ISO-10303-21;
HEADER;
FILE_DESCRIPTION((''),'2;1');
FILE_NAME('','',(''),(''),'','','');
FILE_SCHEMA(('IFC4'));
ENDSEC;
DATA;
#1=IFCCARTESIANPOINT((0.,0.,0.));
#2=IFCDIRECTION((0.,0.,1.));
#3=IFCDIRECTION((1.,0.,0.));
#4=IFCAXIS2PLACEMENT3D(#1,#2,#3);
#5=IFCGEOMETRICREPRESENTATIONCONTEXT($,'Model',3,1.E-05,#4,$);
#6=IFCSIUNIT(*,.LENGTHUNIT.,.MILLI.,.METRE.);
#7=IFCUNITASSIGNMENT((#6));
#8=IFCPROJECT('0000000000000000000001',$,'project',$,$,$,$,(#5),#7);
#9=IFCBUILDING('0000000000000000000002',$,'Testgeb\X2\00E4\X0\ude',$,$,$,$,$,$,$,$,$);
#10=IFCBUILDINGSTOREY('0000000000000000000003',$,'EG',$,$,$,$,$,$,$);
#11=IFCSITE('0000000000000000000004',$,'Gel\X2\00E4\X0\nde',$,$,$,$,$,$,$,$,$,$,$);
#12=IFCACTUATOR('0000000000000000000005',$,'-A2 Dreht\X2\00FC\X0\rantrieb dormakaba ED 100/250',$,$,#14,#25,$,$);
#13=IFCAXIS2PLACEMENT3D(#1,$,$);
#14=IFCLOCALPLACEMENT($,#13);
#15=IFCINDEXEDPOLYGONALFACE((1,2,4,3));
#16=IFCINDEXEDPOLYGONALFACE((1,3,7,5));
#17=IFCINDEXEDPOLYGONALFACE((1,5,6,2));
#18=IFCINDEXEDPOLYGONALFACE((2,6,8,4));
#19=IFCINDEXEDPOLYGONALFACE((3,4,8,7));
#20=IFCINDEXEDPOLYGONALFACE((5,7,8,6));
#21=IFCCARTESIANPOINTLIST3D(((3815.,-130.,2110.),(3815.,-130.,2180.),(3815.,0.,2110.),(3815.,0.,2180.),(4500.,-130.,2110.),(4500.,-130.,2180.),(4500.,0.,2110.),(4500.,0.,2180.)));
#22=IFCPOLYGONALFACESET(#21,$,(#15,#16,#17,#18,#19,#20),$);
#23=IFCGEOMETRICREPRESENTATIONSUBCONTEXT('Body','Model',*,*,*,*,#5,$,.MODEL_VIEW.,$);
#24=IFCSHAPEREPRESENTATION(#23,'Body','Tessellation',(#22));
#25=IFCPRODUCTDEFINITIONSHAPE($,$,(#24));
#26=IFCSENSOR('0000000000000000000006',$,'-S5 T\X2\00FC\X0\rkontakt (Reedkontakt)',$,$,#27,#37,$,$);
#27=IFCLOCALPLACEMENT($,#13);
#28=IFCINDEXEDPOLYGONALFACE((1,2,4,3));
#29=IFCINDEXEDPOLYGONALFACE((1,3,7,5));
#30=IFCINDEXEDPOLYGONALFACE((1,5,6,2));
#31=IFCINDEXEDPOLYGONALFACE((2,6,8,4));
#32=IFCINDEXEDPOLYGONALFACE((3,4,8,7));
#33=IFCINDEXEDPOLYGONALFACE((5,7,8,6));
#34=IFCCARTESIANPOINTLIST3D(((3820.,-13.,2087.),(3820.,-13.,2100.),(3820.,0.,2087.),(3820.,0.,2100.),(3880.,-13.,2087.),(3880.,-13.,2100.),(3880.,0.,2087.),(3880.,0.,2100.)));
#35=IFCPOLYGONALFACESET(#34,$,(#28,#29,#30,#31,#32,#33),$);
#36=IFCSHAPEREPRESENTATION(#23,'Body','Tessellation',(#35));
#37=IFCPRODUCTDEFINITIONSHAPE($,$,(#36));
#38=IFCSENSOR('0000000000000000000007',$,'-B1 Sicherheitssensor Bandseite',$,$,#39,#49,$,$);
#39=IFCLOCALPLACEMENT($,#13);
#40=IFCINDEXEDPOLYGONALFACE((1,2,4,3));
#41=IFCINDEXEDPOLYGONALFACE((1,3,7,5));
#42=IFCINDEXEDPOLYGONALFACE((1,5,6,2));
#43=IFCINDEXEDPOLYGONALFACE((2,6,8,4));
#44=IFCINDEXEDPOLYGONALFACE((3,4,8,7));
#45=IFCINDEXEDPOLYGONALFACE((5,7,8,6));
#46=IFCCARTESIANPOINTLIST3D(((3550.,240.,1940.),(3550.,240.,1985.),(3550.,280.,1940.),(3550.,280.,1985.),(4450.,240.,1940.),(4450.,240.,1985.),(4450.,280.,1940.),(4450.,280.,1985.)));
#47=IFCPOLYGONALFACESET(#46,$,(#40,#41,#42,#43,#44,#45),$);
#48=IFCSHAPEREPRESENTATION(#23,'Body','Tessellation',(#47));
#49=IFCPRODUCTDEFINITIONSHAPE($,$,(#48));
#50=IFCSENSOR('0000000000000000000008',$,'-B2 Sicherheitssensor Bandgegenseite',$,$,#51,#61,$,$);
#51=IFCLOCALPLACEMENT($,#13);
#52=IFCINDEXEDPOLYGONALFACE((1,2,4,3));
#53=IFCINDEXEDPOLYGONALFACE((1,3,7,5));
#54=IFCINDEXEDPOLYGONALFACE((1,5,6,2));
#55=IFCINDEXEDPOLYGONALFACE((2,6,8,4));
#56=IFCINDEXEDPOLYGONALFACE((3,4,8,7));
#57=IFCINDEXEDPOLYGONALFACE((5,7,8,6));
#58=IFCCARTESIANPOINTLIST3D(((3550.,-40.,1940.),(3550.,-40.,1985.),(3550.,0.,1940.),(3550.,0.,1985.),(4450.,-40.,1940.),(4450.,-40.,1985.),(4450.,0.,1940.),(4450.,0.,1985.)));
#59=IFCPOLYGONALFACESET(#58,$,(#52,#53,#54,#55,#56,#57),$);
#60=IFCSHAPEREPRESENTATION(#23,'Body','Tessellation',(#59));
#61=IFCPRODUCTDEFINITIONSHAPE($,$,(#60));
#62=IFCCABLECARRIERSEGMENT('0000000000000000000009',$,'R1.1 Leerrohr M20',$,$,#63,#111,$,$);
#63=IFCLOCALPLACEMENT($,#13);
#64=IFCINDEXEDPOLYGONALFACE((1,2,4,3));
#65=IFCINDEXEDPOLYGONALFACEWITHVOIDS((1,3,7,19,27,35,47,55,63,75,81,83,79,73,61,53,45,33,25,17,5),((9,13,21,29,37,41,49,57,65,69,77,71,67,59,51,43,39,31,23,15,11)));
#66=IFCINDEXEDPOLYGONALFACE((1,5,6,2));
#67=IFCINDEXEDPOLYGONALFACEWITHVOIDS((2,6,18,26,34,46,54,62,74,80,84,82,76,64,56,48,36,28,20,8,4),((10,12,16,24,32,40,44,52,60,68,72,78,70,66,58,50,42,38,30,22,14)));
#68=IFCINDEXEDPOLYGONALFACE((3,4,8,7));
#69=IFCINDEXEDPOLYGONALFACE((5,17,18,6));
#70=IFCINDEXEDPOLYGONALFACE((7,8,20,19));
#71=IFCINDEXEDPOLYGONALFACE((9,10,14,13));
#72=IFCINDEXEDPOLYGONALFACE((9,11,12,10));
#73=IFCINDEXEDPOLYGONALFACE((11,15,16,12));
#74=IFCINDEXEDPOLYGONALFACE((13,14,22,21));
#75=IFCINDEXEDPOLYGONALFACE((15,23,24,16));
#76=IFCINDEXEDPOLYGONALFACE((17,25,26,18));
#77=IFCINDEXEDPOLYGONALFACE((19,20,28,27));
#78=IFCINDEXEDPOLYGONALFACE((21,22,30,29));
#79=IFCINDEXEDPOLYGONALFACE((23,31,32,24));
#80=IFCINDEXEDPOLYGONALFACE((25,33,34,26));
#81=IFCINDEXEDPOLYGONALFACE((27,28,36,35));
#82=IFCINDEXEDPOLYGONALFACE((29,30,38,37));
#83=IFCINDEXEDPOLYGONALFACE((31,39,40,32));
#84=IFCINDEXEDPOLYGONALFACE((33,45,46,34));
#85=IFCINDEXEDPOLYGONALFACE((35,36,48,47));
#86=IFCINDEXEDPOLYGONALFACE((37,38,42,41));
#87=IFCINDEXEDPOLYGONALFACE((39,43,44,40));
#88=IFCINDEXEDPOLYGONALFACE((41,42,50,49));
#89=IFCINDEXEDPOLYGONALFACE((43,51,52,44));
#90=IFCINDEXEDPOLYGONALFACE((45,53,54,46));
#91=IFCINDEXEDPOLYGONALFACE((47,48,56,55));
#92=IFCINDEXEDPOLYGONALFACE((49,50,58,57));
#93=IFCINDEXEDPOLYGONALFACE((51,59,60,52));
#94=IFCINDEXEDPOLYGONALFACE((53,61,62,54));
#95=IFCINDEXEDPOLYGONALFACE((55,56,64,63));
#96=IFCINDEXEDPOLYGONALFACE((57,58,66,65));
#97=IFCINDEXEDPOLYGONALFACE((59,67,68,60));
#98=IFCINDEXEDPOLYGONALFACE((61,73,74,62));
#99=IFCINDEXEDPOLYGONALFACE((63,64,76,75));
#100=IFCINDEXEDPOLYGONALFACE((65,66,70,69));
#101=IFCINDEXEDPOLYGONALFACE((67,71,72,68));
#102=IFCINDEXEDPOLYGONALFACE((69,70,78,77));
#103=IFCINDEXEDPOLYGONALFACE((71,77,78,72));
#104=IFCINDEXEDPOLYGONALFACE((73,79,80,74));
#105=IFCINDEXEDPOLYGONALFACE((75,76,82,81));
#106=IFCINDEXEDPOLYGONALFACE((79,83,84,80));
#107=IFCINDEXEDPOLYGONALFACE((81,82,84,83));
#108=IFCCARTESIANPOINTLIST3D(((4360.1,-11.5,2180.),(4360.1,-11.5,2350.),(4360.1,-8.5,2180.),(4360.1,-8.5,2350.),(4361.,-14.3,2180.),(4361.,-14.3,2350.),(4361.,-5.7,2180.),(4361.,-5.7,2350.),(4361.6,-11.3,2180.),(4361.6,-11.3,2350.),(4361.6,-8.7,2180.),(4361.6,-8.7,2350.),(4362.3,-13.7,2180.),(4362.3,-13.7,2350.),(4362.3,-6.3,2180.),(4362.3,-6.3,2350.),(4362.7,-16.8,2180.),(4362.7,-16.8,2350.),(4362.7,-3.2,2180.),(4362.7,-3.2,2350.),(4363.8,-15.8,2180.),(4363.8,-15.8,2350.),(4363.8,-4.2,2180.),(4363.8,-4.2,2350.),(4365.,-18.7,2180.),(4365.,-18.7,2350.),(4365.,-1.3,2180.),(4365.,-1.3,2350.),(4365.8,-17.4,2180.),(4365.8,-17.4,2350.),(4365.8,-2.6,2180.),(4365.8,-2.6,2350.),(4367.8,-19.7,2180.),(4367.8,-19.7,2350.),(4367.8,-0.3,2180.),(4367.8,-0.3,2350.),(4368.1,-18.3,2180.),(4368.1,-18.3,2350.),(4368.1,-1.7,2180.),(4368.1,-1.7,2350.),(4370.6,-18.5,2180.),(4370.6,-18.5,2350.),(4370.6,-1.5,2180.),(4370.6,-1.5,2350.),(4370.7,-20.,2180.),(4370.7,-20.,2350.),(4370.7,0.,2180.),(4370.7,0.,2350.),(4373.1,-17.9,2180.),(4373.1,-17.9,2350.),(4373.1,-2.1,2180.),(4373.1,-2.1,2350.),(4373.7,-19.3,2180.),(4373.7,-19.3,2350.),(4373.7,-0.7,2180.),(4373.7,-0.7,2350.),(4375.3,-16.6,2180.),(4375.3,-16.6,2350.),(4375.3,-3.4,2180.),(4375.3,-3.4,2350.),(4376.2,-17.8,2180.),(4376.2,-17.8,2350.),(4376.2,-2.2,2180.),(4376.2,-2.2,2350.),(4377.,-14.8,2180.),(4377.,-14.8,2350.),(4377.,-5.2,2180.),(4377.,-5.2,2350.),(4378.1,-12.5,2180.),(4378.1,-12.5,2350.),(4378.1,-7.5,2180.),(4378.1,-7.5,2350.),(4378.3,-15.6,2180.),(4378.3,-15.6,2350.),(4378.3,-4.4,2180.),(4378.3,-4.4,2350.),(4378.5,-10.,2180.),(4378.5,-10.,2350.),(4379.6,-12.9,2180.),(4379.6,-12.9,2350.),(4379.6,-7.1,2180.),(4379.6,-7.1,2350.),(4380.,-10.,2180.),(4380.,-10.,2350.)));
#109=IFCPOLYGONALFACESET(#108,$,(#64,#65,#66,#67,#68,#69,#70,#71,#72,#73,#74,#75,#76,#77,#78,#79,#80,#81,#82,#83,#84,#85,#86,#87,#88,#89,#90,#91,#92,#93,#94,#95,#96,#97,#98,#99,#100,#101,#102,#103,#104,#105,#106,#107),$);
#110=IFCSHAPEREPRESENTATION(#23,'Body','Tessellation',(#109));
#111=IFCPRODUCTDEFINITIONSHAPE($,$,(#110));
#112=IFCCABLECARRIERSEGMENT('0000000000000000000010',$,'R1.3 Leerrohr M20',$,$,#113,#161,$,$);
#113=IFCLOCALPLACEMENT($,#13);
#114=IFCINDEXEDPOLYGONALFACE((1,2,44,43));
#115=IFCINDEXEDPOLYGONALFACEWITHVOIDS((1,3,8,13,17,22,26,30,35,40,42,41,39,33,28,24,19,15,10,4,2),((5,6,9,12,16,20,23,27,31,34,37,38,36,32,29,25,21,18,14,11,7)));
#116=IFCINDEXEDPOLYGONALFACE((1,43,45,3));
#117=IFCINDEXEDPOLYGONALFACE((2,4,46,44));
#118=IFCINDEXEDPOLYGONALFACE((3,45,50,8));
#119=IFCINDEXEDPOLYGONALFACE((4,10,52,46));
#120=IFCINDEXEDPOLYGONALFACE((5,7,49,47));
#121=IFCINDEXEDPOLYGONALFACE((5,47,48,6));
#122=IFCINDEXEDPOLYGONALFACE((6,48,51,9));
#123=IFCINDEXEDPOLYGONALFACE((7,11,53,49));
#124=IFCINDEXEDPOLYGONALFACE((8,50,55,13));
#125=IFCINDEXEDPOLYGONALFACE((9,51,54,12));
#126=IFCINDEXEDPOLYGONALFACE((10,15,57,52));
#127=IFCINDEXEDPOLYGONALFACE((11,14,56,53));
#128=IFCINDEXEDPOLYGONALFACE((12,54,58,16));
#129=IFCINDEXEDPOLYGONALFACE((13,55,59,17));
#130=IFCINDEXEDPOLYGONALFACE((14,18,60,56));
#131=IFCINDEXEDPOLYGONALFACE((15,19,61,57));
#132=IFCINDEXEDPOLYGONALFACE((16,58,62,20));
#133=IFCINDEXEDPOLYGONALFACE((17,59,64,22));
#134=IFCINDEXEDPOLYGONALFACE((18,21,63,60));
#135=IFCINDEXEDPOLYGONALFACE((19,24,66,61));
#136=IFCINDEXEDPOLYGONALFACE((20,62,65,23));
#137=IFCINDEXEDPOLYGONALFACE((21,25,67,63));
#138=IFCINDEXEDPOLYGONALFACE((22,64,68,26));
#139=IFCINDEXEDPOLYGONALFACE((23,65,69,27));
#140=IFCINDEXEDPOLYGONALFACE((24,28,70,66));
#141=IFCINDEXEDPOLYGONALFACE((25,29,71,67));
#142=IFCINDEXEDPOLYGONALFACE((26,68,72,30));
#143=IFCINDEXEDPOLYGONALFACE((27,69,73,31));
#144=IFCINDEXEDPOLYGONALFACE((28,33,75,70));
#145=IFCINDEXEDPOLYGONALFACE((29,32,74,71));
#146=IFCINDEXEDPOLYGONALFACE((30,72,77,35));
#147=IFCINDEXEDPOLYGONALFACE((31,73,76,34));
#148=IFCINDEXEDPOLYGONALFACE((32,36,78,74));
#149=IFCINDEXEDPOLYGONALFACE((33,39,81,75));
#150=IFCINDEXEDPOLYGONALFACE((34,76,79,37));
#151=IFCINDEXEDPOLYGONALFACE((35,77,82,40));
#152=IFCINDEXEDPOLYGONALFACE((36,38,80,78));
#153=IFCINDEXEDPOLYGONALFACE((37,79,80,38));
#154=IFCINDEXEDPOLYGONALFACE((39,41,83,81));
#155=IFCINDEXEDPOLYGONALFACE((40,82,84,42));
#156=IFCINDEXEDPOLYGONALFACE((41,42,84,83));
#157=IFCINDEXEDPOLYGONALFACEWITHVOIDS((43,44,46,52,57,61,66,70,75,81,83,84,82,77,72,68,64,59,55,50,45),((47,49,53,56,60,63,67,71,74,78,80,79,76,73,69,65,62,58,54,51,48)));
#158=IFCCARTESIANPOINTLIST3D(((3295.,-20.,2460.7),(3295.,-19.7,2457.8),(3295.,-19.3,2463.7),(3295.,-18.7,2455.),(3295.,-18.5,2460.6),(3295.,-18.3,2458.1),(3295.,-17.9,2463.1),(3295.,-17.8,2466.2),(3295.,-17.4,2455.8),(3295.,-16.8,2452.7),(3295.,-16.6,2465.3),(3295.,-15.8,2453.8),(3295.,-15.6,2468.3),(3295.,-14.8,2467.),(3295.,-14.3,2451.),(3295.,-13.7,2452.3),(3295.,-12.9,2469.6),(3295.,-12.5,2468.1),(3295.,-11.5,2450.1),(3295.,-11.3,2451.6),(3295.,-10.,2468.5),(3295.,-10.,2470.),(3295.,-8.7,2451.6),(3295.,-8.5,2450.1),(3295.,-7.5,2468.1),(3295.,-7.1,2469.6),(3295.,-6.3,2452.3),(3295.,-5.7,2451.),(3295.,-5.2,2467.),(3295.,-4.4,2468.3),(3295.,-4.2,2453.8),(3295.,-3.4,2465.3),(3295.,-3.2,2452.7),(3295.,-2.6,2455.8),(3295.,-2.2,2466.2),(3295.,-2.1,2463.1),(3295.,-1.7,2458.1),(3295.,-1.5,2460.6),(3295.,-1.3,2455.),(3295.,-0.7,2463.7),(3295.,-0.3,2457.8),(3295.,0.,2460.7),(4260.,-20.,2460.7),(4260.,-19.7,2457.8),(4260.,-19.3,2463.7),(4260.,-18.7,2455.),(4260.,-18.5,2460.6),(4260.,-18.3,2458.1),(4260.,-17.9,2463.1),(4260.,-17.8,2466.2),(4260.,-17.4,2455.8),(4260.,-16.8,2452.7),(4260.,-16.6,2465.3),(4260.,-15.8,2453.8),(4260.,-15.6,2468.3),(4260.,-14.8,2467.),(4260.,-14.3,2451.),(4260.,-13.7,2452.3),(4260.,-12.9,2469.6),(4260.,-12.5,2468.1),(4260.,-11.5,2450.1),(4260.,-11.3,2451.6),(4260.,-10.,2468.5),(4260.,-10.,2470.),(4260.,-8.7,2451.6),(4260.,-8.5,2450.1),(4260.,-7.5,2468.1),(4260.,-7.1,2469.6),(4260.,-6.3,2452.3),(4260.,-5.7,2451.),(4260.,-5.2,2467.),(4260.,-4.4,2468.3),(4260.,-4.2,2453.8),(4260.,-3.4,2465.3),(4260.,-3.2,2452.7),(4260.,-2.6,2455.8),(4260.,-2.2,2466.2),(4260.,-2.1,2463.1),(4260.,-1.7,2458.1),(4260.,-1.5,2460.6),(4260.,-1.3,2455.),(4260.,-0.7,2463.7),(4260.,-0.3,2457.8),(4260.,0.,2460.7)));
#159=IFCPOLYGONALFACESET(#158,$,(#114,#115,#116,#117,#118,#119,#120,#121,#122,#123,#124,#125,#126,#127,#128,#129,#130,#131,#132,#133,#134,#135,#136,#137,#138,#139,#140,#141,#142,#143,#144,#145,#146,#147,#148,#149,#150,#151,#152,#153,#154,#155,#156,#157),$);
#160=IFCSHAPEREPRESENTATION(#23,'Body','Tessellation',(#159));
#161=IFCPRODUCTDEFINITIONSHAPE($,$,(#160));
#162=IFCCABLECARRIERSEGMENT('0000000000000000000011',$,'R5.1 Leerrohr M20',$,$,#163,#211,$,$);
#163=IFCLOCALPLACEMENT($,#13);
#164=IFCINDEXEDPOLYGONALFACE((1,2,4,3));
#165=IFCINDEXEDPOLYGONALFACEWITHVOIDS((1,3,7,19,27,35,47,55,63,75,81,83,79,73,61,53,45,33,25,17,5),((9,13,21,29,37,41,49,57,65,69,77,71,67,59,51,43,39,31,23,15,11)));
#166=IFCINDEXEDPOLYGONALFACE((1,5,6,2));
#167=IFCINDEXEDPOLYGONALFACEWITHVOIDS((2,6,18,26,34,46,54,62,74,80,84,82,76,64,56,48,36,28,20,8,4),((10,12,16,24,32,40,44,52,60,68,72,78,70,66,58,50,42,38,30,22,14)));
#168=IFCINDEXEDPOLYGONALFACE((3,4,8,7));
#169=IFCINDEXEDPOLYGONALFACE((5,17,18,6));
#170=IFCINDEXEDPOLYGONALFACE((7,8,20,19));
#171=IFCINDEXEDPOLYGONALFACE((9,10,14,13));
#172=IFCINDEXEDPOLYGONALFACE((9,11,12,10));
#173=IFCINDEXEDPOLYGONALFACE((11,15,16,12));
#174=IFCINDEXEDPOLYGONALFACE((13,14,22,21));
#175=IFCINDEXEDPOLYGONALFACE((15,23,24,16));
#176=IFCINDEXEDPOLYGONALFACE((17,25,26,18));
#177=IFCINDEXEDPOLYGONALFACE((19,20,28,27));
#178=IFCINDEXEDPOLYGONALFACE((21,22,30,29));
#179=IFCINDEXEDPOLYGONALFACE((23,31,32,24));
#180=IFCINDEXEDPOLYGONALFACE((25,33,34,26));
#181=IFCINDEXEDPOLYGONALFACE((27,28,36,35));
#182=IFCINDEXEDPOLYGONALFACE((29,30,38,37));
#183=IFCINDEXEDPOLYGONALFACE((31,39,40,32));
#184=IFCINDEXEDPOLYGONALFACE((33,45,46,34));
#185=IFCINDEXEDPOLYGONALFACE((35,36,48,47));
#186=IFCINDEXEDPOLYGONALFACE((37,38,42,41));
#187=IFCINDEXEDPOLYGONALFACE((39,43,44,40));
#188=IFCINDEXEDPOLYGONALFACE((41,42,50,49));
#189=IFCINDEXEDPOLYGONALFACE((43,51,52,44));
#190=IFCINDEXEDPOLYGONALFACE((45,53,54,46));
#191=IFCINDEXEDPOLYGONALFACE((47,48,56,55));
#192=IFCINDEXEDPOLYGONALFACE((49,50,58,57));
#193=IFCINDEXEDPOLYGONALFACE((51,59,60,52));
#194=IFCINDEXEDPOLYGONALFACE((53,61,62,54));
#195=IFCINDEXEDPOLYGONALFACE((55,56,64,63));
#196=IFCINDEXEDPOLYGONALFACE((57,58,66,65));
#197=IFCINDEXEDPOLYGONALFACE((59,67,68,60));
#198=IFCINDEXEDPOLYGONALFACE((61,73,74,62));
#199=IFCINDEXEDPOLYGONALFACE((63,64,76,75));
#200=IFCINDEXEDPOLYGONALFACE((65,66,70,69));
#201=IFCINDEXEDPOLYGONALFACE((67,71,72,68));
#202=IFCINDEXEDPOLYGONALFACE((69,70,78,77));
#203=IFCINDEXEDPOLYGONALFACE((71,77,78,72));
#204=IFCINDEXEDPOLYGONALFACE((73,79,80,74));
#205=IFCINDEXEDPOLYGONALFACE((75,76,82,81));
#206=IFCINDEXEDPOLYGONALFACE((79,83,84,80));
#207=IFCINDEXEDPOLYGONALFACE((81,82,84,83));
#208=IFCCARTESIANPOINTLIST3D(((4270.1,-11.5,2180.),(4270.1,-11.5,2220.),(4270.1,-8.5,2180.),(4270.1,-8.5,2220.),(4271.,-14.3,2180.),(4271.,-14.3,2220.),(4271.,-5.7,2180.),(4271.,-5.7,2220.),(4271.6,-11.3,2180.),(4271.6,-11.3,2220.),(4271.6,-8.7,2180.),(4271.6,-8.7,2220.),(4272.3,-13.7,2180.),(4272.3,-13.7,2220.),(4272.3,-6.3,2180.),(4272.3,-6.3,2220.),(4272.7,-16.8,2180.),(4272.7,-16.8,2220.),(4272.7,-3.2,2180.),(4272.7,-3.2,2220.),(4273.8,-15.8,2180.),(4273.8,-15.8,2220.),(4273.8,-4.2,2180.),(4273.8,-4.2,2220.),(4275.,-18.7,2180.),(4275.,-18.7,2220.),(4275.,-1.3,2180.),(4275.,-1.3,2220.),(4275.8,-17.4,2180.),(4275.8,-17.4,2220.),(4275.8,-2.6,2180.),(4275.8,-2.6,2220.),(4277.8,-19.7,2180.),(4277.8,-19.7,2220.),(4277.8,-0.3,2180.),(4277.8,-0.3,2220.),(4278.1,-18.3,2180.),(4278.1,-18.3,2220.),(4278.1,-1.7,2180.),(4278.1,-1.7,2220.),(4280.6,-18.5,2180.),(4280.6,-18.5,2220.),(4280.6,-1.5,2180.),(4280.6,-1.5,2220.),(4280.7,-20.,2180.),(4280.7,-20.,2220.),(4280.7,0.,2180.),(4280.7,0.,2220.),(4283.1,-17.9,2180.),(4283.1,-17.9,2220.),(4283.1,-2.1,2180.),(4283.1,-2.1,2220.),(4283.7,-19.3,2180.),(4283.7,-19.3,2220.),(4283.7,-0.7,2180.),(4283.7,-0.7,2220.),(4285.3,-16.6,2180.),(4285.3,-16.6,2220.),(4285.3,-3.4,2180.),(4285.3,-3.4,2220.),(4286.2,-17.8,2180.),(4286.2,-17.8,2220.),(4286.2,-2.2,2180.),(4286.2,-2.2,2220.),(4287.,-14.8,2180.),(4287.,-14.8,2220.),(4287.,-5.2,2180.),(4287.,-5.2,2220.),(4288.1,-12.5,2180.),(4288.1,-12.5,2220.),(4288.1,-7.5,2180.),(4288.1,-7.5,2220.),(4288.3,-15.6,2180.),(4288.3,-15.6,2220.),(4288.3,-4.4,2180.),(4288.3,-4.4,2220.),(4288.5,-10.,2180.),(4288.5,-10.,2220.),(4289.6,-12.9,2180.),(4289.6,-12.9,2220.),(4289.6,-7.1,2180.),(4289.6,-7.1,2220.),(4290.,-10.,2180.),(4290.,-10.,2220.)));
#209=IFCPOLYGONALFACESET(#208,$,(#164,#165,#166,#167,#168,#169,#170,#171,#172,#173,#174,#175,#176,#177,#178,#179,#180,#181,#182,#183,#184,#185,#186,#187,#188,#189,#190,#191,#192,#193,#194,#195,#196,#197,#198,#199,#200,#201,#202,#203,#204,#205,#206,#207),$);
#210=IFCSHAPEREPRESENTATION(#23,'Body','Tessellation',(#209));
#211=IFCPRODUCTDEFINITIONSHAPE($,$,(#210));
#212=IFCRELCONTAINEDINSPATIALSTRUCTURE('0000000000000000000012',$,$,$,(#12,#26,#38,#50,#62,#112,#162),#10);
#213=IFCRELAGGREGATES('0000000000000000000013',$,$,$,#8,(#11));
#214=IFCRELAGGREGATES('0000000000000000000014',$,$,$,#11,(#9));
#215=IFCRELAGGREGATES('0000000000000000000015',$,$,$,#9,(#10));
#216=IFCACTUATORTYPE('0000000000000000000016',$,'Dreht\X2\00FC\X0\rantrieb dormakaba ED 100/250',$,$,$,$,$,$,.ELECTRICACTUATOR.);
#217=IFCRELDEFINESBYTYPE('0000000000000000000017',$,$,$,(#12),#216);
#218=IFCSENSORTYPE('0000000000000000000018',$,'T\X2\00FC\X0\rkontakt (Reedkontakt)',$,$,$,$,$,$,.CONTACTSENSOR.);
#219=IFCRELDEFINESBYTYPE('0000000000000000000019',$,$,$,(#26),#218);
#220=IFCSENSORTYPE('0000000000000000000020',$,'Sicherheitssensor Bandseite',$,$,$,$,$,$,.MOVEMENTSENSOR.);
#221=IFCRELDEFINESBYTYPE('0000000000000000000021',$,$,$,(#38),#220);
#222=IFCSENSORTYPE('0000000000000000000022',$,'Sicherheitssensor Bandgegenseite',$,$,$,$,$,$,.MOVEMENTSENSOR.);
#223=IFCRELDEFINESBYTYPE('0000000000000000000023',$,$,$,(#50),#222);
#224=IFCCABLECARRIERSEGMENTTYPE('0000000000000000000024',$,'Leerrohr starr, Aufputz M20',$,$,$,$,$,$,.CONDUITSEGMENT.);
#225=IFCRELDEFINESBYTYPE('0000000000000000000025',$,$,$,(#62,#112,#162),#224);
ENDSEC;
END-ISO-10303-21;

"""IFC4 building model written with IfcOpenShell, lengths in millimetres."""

from ifc_helpers import new_model, si_unit, frame, frame_2d, origin_with_axes, place, context, subcontext, project, spatial, rectangle, hollow_circle, extrude, type_object, element, save


model = new_model("IFC4")

# Units and contexts
model_context = context("Model", 3, precision=1e-05, world=origin_with_axes())
body_context = subcontext(model_context, "Body", "Model", "MODEL_VIEW")
ifc_project = project(units=[si_unit("LENGTHUNIT", "METRE", prefix="MILLI")], contexts=[model_context])

# Site, building, storey
site = spatial("IfcSite", under=ifc_project, Name="Gelände")
building = spatial("IfcBuilding", under=site, Name="Testgebäude")
storey = spatial("IfcBuildingStorey", under=building, Name="EG")

# Actuator
actuator_type = type_object("IfcActuatorType", Name="Drehtürantrieb dormakaba ED 100/250", PredefinedType="ELECTRICACTUATOR")
actuator_placement = place(None, frame((3815.0, -130.0, 2110.0), z_axis=(0.0, 0.0, 1.0), x_axis=(1.0, 0.0, 0.0)))
element("IfcActuator", 1, at=actuator_placement, inside=storey, type_object=actuator_type, Name="-A2 Drehtürantrieb dormakaba ED 100/250", context=body_context, shape_type="SweptSolid", body=[
    extrude(rectangle(XDim=685.0, YDim=130.0, at=frame_2d((342.5, 65.0))), None, (0.0, 0.0, 1.0), 70.0),
])

# Sensors
sensor_type_1 = type_object("IfcSensorType", Name="Türkontakt (Reedkontakt)", PredefinedType="CONTACTSENSOR")
sensor_1_placement = place(None, frame((3820.0, -13.0, 2087.0), z_axis=(0.0, 0.0, 1.0), x_axis=(1.0, 0.0, 0.0)))
element("IfcSensor", 2, at=sensor_1_placement, inside=storey, type_object=sensor_type_1, Name="-S5 Türkontakt (Reedkontakt)", context=body_context, shape_type="SweptSolid", body=[
    extrude(rectangle(XDim=60.0, YDim=13.0, at=frame_2d((30.0, 6.5))), None, (0.0, 0.0, 1.0), 13.0),
])
sensor_type_2 = type_object("IfcSensorType", Name="Sicherheitssensor Bandseite", PredefinedType="MOVEMENTSENSOR")
sensor_2_placement = place(None, frame((3550.0, 240.0, 1940.0), z_axis=(0.0, 0.0, 1.0), x_axis=(1.0, 0.0, 0.0)))
element("IfcSensor", 3, at=sensor_2_placement, inside=storey, type_object=sensor_type_2, Name="-B1 Sicherheitssensor Bandseite", context=body_context, shape_type="SweptSolid", body=[
    extrude(rectangle(XDim=900.0, YDim=40.0, at=frame_2d((450.0, 20.0))), None, (0.0, 0.0, 1.0), 45.0),
])
sensor_type_3 = type_object("IfcSensorType", Name="Sicherheitssensor Bandgegenseite", PredefinedType="MOVEMENTSENSOR")
sensor_3_placement = place(None, frame((3550.0, -40.0, 1940.0), z_axis=(0.0, 0.0, 1.0), x_axis=(1.0, 0.0, 0.0)))
element("IfcSensor", 4, at=sensor_3_placement, inside=storey, type_object=sensor_type_3, Name="-B2 Sicherheitssensor Bandgegenseite", context=body_context, shape_type="SweptSolid", body=[
    extrude(rectangle(XDim=900.0, YDim=40.0, at=frame_2d((450.0, 20.0))), None, (0.0, 0.0, 1.0), 45.0),
])

# Cable carrier segments
cable_carrier_segment_type_1 = type_object("IfcCableCarrierSegmentType", Name="Leerrohr starr, Aufputz M20", PredefinedType="CONDUITSEGMENT")
cable_carrier_segment_1_placement = place(None, frame((4370.0, -10.0, 2180.0), z_axis=(0.0, 0.0, 1.0), x_axis=(1.0, 0.0, 0.0)))
element("IfcCableCarrierSegment", 5, at=cable_carrier_segment_1_placement, inside=storey, type_object=cable_carrier_segment_type_1, Name="R1.1 Leerrohr M20", context=body_context, shape_type="SweptSolid", body=[
    extrude(hollow_circle(Radius=10.0, WallThickness=1.5), None, (0.0, 0.0, 1.0), 170.0),
])
cable_carrier_segment_2_placement = place(None, frame((4260.0, -10.0, 2460.0), z_axis=(-1.0, 0.0, 0.0), x_axis=(0.0, 0.0, 1.0)))
element("IfcCableCarrierSegment", 6, at=cable_carrier_segment_2_placement, inside=storey, type_object=cable_carrier_segment_type_1, Name="R1.3 Leerrohr M20", context=body_context, shape_type="SweptSolid", body=[
    extrude(hollow_circle(Radius=10.0, WallThickness=1.5), None, (0.0, 0.0, 1.0), 965.0),
])
cable_carrier_segment_3_placement = place(None, frame((4280.0, -10.0, 2180.0), z_axis=(0.0, 0.0, 1.0), x_axis=(1.0, 0.0, 0.0)))
element("IfcCableCarrierSegment", 7, at=cable_carrier_segment_3_placement, inside=storey, type_object=cable_carrier_segment_type_1, Name="R5.1 Leerrohr M20", context=body_context, shape_type="SweptSolid", body=[
    extrude(hollow_circle(Radius=10.0, WallThickness=1.5), None, (0.0, 0.0, 1.0), 40.0),
])

save(model, "model.ifc")
